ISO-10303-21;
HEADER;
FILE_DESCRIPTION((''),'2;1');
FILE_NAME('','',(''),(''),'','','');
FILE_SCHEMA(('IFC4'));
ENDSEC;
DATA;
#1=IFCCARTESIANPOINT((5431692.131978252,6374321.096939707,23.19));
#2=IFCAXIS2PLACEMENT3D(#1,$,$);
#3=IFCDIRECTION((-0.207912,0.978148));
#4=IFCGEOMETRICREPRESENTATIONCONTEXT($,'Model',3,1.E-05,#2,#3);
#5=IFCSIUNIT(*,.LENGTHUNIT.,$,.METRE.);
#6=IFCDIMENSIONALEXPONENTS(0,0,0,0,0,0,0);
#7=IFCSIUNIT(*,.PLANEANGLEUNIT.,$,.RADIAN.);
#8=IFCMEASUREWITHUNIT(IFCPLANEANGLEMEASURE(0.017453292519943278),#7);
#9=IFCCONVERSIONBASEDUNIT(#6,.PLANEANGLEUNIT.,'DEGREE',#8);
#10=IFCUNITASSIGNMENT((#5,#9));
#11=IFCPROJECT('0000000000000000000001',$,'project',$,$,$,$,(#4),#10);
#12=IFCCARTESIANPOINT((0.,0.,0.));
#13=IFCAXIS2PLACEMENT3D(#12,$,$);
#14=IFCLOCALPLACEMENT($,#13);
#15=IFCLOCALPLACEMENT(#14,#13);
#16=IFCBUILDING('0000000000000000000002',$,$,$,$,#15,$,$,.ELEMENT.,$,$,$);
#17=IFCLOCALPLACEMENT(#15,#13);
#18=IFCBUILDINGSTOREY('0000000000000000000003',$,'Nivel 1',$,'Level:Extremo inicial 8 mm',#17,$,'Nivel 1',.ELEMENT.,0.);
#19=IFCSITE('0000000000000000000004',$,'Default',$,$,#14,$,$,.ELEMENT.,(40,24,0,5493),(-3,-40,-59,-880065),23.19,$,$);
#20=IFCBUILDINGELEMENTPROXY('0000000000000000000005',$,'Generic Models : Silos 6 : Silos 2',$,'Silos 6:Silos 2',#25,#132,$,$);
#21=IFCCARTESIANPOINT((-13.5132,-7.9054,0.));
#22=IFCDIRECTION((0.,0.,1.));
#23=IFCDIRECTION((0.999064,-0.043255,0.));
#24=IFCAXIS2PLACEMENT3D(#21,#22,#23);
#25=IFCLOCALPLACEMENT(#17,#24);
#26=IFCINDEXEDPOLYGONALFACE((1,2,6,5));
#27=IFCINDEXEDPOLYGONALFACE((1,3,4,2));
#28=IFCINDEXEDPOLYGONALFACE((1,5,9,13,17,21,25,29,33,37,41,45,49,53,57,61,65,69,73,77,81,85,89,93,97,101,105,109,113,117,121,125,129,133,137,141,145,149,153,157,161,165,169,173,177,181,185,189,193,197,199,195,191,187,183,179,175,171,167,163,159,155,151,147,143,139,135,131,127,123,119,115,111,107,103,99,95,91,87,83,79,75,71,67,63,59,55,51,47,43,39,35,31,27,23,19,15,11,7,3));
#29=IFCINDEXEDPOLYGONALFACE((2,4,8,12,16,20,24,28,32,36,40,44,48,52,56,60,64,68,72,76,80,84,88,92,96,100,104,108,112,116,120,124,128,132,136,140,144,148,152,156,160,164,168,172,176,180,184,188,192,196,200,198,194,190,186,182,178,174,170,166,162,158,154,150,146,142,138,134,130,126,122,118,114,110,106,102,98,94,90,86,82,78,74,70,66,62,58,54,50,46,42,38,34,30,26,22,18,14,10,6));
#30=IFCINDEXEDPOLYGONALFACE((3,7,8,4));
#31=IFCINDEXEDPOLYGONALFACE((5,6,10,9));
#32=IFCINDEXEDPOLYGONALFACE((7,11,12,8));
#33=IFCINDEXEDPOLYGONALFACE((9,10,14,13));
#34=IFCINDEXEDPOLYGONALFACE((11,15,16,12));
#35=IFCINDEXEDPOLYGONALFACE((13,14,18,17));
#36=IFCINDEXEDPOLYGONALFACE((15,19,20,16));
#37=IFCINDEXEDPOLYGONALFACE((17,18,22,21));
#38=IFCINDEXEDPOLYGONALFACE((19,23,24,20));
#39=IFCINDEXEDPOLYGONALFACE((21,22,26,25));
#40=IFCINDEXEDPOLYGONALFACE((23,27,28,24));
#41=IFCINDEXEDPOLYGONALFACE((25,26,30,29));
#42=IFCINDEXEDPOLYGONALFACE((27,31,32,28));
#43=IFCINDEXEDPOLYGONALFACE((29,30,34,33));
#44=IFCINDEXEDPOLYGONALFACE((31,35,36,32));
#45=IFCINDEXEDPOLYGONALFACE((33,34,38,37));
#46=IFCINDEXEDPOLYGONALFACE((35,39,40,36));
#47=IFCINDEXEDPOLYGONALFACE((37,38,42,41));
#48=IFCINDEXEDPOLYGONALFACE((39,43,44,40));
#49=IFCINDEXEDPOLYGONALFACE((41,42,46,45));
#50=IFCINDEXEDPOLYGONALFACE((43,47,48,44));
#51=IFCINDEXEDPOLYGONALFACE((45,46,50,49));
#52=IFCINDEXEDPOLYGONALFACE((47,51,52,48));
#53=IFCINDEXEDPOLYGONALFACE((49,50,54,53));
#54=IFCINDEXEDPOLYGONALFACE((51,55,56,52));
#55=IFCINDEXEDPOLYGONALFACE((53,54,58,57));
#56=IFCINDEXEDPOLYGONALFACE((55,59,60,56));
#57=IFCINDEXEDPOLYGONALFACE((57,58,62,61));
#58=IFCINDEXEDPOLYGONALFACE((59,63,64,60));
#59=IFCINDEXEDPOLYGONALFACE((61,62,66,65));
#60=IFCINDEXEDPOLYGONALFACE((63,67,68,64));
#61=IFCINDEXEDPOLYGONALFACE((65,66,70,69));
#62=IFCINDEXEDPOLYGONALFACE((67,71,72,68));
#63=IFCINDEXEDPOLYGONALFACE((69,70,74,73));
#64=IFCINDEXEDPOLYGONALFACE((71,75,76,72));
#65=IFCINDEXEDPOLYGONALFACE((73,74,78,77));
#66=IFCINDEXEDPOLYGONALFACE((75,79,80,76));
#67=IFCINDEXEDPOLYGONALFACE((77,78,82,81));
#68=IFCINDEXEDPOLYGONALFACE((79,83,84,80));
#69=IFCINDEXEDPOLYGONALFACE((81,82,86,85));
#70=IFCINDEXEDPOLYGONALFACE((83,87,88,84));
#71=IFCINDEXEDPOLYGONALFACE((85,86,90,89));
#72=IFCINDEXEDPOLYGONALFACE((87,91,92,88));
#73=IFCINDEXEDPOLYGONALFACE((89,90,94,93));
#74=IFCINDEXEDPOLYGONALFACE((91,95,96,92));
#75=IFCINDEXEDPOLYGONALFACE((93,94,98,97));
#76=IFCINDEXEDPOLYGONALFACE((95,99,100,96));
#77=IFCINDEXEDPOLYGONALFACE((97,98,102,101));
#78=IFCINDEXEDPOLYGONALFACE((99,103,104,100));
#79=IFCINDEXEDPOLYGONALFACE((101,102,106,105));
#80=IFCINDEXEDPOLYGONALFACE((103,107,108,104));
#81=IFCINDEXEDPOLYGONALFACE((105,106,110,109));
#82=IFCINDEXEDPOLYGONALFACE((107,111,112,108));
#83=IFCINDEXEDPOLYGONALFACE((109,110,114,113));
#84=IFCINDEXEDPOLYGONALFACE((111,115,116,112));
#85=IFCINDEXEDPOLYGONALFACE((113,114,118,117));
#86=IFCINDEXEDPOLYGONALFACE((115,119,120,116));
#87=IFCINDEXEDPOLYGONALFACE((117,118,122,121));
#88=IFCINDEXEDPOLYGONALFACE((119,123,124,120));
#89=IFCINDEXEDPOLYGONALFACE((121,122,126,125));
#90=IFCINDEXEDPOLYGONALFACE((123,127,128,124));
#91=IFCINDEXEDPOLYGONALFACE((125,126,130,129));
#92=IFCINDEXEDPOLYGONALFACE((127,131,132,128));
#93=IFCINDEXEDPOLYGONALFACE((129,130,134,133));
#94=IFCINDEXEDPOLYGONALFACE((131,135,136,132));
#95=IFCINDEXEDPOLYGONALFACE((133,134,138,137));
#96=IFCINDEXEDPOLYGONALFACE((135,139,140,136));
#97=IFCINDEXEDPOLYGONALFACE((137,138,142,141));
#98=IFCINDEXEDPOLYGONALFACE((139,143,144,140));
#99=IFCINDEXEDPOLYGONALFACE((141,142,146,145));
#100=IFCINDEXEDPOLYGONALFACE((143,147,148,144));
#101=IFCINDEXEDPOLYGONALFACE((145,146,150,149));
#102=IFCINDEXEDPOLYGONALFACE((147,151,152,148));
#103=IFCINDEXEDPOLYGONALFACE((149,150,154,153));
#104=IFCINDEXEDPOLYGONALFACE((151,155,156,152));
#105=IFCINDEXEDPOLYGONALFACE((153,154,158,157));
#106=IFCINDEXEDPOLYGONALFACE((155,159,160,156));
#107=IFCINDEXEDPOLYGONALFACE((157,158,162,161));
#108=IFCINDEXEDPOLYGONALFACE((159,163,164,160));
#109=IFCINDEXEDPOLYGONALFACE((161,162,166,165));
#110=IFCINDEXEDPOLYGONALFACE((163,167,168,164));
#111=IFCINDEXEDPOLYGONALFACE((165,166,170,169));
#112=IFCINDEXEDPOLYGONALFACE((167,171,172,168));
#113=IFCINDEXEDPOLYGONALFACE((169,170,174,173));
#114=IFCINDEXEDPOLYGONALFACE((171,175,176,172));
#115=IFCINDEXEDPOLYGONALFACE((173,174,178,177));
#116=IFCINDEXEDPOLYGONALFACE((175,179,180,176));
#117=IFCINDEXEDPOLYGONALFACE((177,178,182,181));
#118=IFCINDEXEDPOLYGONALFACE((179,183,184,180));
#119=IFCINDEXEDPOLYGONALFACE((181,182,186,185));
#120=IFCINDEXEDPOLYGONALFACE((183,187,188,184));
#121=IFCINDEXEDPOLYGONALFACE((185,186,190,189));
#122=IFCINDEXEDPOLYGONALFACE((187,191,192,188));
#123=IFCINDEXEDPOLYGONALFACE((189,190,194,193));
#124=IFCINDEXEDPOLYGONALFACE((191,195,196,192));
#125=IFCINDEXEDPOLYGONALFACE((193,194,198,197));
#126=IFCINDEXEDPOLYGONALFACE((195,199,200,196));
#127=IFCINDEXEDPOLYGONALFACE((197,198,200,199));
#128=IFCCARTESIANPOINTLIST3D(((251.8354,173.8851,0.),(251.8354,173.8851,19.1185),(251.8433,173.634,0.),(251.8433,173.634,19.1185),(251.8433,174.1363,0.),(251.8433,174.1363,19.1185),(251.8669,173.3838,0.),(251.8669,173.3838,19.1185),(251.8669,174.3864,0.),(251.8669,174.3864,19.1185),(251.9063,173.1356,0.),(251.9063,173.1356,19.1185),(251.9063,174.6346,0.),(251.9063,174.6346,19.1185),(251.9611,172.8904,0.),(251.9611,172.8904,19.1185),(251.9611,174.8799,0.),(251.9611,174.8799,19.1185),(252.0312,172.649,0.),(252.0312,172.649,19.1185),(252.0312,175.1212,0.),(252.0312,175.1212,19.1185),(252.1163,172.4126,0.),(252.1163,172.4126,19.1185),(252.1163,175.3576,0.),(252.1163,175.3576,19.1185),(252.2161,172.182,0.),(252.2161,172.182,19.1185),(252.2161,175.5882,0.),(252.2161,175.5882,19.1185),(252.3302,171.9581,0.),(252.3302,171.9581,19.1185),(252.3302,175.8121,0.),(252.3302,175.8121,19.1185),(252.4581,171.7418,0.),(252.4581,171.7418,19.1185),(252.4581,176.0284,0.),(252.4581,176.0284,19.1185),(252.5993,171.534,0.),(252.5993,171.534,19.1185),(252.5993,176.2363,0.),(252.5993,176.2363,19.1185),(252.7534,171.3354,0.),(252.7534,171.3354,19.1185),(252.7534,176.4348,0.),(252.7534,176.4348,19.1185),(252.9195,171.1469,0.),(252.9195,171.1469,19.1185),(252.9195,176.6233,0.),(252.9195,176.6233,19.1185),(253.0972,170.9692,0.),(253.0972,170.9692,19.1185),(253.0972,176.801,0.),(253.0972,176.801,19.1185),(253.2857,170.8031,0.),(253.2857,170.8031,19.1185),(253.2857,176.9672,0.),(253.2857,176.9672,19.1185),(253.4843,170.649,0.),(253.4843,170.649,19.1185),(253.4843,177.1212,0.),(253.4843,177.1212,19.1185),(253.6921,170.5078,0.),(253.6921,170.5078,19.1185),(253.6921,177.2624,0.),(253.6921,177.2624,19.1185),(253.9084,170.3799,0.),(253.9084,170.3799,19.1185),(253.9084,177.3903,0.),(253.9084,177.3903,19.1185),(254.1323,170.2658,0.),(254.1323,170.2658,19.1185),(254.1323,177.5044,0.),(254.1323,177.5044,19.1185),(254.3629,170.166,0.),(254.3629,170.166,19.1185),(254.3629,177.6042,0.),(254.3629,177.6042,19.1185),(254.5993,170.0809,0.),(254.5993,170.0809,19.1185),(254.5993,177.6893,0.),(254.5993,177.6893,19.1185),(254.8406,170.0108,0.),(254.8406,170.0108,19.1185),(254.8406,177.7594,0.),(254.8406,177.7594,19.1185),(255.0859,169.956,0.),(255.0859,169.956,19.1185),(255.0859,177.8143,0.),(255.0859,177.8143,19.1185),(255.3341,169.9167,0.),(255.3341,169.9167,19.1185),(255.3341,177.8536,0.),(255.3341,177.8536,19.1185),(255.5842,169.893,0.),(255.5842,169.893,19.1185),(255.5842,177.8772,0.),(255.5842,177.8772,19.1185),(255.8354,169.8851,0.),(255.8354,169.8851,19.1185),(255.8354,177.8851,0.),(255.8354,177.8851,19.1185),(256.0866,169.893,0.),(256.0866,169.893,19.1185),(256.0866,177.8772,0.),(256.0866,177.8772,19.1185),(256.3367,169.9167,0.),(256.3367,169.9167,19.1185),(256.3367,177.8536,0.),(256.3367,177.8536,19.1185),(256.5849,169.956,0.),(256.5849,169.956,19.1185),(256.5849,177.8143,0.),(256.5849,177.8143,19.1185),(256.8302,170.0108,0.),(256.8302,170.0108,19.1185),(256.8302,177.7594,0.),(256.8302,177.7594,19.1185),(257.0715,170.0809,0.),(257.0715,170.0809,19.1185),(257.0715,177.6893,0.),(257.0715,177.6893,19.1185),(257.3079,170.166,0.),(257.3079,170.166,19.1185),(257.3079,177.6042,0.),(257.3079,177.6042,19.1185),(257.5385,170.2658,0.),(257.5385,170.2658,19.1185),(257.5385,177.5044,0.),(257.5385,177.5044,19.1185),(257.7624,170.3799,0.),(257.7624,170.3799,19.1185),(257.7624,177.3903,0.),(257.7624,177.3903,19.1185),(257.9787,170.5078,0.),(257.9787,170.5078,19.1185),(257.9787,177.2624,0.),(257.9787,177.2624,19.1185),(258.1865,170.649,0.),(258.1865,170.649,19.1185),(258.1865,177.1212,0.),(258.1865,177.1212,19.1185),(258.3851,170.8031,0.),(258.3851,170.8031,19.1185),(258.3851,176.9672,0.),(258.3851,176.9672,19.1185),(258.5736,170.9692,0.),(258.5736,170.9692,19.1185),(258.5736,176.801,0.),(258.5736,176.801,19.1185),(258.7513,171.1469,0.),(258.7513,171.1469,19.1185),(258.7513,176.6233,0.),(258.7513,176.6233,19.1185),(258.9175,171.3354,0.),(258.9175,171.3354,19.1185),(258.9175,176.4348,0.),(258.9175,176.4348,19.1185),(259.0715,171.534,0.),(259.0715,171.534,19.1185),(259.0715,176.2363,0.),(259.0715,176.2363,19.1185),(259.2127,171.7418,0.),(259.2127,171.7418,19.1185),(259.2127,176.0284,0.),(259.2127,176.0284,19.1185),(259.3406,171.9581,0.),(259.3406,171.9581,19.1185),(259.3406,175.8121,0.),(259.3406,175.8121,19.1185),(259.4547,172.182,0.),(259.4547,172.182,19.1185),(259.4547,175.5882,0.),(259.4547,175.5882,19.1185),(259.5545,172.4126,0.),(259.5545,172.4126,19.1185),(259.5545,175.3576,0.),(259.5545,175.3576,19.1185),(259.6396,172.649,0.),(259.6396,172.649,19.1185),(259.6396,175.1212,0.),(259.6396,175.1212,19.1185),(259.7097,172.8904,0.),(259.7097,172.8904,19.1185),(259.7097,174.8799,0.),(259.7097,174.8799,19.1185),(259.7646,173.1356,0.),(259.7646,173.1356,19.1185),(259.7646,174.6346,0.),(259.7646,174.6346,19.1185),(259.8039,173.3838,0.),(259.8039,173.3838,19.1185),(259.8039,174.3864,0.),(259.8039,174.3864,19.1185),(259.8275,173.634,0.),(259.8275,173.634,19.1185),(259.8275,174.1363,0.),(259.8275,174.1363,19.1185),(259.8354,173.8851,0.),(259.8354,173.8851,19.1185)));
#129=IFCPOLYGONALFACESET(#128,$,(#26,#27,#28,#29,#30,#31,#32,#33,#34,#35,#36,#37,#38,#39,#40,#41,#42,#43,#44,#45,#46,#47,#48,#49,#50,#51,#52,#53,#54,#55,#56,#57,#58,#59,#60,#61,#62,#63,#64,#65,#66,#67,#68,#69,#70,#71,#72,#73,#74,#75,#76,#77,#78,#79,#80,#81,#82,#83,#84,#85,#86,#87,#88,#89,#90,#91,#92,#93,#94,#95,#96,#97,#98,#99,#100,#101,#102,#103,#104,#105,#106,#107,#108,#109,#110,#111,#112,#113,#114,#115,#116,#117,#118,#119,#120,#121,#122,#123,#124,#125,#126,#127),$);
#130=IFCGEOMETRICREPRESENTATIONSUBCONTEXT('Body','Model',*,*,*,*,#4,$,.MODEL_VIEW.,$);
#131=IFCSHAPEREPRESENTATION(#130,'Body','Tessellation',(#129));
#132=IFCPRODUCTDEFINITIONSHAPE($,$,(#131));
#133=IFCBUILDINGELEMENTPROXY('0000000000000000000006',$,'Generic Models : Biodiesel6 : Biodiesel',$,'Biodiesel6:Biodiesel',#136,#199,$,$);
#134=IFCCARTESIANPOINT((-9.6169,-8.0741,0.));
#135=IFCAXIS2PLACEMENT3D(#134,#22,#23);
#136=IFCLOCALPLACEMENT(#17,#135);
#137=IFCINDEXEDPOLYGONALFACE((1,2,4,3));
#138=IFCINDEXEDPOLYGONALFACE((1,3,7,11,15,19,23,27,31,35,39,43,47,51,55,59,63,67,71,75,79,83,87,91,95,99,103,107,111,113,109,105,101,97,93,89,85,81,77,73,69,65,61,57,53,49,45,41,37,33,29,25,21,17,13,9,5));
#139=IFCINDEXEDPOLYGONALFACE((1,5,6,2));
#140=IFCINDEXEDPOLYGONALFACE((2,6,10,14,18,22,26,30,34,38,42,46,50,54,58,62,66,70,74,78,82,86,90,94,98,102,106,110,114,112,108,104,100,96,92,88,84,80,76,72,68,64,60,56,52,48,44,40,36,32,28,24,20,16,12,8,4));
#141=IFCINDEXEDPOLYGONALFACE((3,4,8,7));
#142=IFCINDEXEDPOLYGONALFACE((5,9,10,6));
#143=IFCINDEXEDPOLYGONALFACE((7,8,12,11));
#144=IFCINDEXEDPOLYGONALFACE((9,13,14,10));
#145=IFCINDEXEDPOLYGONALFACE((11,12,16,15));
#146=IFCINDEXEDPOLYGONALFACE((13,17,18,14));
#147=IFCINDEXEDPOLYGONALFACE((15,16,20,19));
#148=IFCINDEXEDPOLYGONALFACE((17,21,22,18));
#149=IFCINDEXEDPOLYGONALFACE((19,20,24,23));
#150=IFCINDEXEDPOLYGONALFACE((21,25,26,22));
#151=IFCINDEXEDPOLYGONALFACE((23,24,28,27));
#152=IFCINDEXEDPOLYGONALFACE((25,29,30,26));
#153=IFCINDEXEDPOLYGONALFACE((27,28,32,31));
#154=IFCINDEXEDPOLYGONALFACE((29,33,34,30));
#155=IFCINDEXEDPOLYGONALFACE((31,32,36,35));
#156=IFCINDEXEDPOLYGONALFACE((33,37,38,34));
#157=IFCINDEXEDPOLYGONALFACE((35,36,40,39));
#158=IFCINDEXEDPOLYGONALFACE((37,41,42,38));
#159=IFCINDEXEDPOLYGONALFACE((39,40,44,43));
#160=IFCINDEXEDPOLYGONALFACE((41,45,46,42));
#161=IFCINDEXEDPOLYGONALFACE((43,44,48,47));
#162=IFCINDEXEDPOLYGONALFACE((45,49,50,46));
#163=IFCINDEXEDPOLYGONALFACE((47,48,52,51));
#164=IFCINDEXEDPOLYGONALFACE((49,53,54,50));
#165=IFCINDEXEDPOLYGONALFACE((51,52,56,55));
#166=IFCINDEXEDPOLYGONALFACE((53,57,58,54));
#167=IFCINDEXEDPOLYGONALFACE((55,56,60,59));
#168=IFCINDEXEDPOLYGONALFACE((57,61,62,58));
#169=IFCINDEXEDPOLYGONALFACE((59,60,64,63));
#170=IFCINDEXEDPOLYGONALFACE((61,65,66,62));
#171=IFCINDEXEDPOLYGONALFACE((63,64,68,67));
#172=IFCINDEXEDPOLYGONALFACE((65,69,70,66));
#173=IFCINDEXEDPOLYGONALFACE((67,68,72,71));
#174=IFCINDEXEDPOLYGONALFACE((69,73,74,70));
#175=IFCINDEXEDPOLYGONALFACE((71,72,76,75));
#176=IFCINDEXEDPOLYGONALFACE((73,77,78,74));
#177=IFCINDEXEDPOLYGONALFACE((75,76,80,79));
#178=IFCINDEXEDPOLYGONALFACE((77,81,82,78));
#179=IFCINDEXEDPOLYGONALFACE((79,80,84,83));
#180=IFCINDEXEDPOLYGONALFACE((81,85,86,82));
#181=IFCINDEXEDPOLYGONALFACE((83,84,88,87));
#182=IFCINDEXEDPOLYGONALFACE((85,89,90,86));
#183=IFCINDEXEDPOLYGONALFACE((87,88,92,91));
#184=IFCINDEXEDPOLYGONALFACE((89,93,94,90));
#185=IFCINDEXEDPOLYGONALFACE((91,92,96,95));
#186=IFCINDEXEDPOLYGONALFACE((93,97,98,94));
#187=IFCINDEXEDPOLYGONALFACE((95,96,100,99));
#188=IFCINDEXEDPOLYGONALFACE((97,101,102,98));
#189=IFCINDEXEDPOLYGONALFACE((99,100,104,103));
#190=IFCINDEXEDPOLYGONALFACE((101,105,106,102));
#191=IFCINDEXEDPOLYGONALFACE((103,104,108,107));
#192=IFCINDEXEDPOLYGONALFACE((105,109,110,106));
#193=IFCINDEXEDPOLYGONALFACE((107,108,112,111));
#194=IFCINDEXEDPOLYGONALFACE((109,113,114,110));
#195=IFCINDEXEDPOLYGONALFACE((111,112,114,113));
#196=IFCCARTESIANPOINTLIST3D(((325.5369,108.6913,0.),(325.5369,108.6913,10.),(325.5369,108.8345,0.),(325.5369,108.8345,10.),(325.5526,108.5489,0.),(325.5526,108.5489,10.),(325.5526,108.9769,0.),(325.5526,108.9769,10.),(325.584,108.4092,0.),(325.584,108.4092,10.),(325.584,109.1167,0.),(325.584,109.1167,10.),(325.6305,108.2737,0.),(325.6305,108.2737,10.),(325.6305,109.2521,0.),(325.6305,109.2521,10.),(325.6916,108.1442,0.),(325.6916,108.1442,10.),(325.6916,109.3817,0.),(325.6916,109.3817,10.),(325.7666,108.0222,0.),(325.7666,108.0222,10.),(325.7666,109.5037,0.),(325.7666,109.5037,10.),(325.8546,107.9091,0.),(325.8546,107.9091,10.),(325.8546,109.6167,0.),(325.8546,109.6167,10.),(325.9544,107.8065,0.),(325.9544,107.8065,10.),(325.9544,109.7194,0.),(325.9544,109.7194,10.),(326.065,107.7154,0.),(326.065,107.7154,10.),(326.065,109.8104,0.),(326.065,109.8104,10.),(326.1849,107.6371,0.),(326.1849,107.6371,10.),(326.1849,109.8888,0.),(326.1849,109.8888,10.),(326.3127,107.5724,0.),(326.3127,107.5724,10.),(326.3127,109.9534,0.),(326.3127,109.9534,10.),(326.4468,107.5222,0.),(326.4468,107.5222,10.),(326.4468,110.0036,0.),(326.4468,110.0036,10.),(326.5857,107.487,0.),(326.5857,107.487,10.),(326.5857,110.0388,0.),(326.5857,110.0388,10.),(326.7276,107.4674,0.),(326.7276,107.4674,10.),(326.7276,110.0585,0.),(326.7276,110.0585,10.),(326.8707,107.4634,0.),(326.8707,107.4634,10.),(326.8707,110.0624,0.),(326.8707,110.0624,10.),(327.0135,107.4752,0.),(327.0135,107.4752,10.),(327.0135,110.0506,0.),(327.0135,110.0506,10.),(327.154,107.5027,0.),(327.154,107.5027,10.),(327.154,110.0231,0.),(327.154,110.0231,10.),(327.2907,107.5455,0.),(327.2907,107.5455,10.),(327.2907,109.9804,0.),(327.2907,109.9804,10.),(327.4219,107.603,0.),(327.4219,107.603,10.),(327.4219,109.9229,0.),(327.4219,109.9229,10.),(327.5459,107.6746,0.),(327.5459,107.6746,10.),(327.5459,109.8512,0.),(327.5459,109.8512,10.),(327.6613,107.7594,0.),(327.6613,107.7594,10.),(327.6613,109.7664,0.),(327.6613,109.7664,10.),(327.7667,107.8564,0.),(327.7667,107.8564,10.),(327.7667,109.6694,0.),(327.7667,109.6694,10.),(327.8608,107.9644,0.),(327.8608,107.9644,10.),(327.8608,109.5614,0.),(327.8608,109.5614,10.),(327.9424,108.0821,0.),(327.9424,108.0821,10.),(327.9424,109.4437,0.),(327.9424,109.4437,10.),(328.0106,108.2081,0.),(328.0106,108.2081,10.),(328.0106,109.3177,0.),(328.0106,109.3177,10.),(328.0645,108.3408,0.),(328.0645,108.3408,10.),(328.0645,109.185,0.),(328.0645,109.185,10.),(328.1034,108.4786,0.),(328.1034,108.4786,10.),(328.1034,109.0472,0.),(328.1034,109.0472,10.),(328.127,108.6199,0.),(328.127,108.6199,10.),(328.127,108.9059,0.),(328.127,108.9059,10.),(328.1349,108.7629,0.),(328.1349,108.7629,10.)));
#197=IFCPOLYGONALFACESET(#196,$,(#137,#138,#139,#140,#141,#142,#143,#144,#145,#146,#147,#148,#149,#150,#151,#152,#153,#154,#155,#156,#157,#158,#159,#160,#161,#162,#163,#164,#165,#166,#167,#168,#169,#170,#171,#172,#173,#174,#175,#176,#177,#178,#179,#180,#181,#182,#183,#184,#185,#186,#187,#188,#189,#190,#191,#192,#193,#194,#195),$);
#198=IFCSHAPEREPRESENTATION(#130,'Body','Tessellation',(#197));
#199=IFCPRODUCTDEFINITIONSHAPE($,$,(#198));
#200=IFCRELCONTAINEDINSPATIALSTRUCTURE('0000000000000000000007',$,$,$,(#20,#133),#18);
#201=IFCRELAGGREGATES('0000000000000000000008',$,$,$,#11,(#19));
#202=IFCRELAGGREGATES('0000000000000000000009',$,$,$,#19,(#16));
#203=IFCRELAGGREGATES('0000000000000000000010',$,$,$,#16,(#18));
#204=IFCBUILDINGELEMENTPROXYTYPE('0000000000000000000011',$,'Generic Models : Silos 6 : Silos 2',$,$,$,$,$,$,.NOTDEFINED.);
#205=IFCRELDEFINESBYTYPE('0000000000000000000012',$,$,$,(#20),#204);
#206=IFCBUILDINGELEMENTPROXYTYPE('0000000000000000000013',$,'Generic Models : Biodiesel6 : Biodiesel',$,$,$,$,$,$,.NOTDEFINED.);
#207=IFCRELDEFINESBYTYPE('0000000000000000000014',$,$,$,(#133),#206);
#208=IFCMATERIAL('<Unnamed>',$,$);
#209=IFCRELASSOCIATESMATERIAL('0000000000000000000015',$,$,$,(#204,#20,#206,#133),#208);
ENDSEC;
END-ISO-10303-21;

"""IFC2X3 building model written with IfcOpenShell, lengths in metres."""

from ifc_helpers import new_model, entity, si_unit, converted_unit, direction, frame, origin, origin_2d_with_axis, place, context, subcontext, project, spatial, circle, extrude, source, transform, mapped, material, type_object, type_shapes, element, save


model = new_model("IFC2X3")

# Units and contexts
model_context = context("Model", 3, precision=1e-05, world=frame((5431692.131978252, 6374321.096939707, 23.19)), true_north=direction((-0.207912, 0.978148)))
body_context = subcontext(model_context, "Body", "Model", "MODEL_VIEW")
ifc_project = project(units=[si_unit("LENGTHUNIT", "METRE"), converted_unit("PLANEANGLEUNIT", "DEGREE", entity("IfcPlaneAngleMeasure", 0.017453292519943278), si_unit("PLANEANGLEUNIT", "RADIAN"), dimensions=[0, 0, 0, 0, 0, 0, 0])], contexts=[model_context])

# Site, building, storey
site_placement = place(None, origin())
site = spatial("IfcSite", under=ifc_project, at=site_placement, Name="Default", CompositionType="ELEMENT", RefLatitude=(40, 24, 0, 5493), RefLongitude=(-3, -40, -59, -880065), RefElevation=23.19)
building_placement = place(site_placement, origin())
building = spatial("IfcBuilding", under=site, at=building_placement, CompositionType="ELEMENT")
storey_placement = place(building_placement, origin())
storey = spatial("IfcBuildingStorey", under=building, at=storey_placement, Name="Nivel 1", ObjectType="Level:Extremo inicial 8 mm", LongName="Nivel 1", CompositionType="ELEMENT", Elevation=0.0)

# Building element proxies
ifc_material_1 = material(Name="<Unnamed>")
building_element_proxy_type_1 = type_object("IfcBuildingElementProxyType", Name="Generic Models : Silos 6 : Silos 2", PredefinedType="NOTDEFINED", material=ifc_material_1)
shared_shape_1 = source(origin(), body_context, "Body", "SweptSolid", [
    extrude(circle(Radius=4.0, at=origin_2d_with_axis()), frame((255.8354, 173.8851, 0.0)), (0.0, 0.0, 1.0), 19.1185),
])
type_shapes(building_element_proxy_type_1, [shared_shape_1])
proxy_1_placement = place(storey_placement, frame((-13.5132, -7.9054, 0.0), z_axis=(0.0, 0.0, 1.0), x_axis=(0.999064, -0.043255, 0.0)))
element("IfcBuildingElementProxy", 1, at=proxy_1_placement, inside=storey, type_object=building_element_proxy_type_1, material=ifc_material_1, Name="Generic Models : Silos 6 : Silos 2", ObjectType="Silos 6:Silos 2", context=body_context, shape_type="MappedRepresentation", body=[
    mapped(shared_shape_1, transform((0.0, 0.0, 0.0), scale=1.0)),
])
building_element_proxy_type_2 = type_object("IfcBuildingElementProxyType", Name="Generic Models : Biodiesel6 : Biodiesel", PredefinedType="NOTDEFINED", material=ifc_material_1)
shared_shape_2 = source(origin(), body_context, "Body", "SweptSolid", [
    extrude(circle(Radius=1.3, at=origin_2d_with_axis()), frame((326.8349, 108.7629, 0.0)), (0.0, 0.0, 1.0), 10.0),
])
type_shapes(building_element_proxy_type_2, [shared_shape_2])
proxy_2_placement = place(storey_placement, frame((-9.6169, -8.0741, 0.0), z_axis=(0.0, 0.0, 1.0), x_axis=(0.999064, -0.043255, 0.0)))
element("IfcBuildingElementProxy", 2, at=proxy_2_placement, inside=storey, type_object=building_element_proxy_type_2, material=ifc_material_1, Name="Generic Models : Biodiesel6 : Biodiesel", ObjectType="Biodiesel6:Biodiesel", context=body_context, shape_type="MappedRepresentation", body=[
    mapped(shared_shape_2, transform((0.0, 0.0, 0.0), scale=1.0)),
])

save(model, "model.ifc")
